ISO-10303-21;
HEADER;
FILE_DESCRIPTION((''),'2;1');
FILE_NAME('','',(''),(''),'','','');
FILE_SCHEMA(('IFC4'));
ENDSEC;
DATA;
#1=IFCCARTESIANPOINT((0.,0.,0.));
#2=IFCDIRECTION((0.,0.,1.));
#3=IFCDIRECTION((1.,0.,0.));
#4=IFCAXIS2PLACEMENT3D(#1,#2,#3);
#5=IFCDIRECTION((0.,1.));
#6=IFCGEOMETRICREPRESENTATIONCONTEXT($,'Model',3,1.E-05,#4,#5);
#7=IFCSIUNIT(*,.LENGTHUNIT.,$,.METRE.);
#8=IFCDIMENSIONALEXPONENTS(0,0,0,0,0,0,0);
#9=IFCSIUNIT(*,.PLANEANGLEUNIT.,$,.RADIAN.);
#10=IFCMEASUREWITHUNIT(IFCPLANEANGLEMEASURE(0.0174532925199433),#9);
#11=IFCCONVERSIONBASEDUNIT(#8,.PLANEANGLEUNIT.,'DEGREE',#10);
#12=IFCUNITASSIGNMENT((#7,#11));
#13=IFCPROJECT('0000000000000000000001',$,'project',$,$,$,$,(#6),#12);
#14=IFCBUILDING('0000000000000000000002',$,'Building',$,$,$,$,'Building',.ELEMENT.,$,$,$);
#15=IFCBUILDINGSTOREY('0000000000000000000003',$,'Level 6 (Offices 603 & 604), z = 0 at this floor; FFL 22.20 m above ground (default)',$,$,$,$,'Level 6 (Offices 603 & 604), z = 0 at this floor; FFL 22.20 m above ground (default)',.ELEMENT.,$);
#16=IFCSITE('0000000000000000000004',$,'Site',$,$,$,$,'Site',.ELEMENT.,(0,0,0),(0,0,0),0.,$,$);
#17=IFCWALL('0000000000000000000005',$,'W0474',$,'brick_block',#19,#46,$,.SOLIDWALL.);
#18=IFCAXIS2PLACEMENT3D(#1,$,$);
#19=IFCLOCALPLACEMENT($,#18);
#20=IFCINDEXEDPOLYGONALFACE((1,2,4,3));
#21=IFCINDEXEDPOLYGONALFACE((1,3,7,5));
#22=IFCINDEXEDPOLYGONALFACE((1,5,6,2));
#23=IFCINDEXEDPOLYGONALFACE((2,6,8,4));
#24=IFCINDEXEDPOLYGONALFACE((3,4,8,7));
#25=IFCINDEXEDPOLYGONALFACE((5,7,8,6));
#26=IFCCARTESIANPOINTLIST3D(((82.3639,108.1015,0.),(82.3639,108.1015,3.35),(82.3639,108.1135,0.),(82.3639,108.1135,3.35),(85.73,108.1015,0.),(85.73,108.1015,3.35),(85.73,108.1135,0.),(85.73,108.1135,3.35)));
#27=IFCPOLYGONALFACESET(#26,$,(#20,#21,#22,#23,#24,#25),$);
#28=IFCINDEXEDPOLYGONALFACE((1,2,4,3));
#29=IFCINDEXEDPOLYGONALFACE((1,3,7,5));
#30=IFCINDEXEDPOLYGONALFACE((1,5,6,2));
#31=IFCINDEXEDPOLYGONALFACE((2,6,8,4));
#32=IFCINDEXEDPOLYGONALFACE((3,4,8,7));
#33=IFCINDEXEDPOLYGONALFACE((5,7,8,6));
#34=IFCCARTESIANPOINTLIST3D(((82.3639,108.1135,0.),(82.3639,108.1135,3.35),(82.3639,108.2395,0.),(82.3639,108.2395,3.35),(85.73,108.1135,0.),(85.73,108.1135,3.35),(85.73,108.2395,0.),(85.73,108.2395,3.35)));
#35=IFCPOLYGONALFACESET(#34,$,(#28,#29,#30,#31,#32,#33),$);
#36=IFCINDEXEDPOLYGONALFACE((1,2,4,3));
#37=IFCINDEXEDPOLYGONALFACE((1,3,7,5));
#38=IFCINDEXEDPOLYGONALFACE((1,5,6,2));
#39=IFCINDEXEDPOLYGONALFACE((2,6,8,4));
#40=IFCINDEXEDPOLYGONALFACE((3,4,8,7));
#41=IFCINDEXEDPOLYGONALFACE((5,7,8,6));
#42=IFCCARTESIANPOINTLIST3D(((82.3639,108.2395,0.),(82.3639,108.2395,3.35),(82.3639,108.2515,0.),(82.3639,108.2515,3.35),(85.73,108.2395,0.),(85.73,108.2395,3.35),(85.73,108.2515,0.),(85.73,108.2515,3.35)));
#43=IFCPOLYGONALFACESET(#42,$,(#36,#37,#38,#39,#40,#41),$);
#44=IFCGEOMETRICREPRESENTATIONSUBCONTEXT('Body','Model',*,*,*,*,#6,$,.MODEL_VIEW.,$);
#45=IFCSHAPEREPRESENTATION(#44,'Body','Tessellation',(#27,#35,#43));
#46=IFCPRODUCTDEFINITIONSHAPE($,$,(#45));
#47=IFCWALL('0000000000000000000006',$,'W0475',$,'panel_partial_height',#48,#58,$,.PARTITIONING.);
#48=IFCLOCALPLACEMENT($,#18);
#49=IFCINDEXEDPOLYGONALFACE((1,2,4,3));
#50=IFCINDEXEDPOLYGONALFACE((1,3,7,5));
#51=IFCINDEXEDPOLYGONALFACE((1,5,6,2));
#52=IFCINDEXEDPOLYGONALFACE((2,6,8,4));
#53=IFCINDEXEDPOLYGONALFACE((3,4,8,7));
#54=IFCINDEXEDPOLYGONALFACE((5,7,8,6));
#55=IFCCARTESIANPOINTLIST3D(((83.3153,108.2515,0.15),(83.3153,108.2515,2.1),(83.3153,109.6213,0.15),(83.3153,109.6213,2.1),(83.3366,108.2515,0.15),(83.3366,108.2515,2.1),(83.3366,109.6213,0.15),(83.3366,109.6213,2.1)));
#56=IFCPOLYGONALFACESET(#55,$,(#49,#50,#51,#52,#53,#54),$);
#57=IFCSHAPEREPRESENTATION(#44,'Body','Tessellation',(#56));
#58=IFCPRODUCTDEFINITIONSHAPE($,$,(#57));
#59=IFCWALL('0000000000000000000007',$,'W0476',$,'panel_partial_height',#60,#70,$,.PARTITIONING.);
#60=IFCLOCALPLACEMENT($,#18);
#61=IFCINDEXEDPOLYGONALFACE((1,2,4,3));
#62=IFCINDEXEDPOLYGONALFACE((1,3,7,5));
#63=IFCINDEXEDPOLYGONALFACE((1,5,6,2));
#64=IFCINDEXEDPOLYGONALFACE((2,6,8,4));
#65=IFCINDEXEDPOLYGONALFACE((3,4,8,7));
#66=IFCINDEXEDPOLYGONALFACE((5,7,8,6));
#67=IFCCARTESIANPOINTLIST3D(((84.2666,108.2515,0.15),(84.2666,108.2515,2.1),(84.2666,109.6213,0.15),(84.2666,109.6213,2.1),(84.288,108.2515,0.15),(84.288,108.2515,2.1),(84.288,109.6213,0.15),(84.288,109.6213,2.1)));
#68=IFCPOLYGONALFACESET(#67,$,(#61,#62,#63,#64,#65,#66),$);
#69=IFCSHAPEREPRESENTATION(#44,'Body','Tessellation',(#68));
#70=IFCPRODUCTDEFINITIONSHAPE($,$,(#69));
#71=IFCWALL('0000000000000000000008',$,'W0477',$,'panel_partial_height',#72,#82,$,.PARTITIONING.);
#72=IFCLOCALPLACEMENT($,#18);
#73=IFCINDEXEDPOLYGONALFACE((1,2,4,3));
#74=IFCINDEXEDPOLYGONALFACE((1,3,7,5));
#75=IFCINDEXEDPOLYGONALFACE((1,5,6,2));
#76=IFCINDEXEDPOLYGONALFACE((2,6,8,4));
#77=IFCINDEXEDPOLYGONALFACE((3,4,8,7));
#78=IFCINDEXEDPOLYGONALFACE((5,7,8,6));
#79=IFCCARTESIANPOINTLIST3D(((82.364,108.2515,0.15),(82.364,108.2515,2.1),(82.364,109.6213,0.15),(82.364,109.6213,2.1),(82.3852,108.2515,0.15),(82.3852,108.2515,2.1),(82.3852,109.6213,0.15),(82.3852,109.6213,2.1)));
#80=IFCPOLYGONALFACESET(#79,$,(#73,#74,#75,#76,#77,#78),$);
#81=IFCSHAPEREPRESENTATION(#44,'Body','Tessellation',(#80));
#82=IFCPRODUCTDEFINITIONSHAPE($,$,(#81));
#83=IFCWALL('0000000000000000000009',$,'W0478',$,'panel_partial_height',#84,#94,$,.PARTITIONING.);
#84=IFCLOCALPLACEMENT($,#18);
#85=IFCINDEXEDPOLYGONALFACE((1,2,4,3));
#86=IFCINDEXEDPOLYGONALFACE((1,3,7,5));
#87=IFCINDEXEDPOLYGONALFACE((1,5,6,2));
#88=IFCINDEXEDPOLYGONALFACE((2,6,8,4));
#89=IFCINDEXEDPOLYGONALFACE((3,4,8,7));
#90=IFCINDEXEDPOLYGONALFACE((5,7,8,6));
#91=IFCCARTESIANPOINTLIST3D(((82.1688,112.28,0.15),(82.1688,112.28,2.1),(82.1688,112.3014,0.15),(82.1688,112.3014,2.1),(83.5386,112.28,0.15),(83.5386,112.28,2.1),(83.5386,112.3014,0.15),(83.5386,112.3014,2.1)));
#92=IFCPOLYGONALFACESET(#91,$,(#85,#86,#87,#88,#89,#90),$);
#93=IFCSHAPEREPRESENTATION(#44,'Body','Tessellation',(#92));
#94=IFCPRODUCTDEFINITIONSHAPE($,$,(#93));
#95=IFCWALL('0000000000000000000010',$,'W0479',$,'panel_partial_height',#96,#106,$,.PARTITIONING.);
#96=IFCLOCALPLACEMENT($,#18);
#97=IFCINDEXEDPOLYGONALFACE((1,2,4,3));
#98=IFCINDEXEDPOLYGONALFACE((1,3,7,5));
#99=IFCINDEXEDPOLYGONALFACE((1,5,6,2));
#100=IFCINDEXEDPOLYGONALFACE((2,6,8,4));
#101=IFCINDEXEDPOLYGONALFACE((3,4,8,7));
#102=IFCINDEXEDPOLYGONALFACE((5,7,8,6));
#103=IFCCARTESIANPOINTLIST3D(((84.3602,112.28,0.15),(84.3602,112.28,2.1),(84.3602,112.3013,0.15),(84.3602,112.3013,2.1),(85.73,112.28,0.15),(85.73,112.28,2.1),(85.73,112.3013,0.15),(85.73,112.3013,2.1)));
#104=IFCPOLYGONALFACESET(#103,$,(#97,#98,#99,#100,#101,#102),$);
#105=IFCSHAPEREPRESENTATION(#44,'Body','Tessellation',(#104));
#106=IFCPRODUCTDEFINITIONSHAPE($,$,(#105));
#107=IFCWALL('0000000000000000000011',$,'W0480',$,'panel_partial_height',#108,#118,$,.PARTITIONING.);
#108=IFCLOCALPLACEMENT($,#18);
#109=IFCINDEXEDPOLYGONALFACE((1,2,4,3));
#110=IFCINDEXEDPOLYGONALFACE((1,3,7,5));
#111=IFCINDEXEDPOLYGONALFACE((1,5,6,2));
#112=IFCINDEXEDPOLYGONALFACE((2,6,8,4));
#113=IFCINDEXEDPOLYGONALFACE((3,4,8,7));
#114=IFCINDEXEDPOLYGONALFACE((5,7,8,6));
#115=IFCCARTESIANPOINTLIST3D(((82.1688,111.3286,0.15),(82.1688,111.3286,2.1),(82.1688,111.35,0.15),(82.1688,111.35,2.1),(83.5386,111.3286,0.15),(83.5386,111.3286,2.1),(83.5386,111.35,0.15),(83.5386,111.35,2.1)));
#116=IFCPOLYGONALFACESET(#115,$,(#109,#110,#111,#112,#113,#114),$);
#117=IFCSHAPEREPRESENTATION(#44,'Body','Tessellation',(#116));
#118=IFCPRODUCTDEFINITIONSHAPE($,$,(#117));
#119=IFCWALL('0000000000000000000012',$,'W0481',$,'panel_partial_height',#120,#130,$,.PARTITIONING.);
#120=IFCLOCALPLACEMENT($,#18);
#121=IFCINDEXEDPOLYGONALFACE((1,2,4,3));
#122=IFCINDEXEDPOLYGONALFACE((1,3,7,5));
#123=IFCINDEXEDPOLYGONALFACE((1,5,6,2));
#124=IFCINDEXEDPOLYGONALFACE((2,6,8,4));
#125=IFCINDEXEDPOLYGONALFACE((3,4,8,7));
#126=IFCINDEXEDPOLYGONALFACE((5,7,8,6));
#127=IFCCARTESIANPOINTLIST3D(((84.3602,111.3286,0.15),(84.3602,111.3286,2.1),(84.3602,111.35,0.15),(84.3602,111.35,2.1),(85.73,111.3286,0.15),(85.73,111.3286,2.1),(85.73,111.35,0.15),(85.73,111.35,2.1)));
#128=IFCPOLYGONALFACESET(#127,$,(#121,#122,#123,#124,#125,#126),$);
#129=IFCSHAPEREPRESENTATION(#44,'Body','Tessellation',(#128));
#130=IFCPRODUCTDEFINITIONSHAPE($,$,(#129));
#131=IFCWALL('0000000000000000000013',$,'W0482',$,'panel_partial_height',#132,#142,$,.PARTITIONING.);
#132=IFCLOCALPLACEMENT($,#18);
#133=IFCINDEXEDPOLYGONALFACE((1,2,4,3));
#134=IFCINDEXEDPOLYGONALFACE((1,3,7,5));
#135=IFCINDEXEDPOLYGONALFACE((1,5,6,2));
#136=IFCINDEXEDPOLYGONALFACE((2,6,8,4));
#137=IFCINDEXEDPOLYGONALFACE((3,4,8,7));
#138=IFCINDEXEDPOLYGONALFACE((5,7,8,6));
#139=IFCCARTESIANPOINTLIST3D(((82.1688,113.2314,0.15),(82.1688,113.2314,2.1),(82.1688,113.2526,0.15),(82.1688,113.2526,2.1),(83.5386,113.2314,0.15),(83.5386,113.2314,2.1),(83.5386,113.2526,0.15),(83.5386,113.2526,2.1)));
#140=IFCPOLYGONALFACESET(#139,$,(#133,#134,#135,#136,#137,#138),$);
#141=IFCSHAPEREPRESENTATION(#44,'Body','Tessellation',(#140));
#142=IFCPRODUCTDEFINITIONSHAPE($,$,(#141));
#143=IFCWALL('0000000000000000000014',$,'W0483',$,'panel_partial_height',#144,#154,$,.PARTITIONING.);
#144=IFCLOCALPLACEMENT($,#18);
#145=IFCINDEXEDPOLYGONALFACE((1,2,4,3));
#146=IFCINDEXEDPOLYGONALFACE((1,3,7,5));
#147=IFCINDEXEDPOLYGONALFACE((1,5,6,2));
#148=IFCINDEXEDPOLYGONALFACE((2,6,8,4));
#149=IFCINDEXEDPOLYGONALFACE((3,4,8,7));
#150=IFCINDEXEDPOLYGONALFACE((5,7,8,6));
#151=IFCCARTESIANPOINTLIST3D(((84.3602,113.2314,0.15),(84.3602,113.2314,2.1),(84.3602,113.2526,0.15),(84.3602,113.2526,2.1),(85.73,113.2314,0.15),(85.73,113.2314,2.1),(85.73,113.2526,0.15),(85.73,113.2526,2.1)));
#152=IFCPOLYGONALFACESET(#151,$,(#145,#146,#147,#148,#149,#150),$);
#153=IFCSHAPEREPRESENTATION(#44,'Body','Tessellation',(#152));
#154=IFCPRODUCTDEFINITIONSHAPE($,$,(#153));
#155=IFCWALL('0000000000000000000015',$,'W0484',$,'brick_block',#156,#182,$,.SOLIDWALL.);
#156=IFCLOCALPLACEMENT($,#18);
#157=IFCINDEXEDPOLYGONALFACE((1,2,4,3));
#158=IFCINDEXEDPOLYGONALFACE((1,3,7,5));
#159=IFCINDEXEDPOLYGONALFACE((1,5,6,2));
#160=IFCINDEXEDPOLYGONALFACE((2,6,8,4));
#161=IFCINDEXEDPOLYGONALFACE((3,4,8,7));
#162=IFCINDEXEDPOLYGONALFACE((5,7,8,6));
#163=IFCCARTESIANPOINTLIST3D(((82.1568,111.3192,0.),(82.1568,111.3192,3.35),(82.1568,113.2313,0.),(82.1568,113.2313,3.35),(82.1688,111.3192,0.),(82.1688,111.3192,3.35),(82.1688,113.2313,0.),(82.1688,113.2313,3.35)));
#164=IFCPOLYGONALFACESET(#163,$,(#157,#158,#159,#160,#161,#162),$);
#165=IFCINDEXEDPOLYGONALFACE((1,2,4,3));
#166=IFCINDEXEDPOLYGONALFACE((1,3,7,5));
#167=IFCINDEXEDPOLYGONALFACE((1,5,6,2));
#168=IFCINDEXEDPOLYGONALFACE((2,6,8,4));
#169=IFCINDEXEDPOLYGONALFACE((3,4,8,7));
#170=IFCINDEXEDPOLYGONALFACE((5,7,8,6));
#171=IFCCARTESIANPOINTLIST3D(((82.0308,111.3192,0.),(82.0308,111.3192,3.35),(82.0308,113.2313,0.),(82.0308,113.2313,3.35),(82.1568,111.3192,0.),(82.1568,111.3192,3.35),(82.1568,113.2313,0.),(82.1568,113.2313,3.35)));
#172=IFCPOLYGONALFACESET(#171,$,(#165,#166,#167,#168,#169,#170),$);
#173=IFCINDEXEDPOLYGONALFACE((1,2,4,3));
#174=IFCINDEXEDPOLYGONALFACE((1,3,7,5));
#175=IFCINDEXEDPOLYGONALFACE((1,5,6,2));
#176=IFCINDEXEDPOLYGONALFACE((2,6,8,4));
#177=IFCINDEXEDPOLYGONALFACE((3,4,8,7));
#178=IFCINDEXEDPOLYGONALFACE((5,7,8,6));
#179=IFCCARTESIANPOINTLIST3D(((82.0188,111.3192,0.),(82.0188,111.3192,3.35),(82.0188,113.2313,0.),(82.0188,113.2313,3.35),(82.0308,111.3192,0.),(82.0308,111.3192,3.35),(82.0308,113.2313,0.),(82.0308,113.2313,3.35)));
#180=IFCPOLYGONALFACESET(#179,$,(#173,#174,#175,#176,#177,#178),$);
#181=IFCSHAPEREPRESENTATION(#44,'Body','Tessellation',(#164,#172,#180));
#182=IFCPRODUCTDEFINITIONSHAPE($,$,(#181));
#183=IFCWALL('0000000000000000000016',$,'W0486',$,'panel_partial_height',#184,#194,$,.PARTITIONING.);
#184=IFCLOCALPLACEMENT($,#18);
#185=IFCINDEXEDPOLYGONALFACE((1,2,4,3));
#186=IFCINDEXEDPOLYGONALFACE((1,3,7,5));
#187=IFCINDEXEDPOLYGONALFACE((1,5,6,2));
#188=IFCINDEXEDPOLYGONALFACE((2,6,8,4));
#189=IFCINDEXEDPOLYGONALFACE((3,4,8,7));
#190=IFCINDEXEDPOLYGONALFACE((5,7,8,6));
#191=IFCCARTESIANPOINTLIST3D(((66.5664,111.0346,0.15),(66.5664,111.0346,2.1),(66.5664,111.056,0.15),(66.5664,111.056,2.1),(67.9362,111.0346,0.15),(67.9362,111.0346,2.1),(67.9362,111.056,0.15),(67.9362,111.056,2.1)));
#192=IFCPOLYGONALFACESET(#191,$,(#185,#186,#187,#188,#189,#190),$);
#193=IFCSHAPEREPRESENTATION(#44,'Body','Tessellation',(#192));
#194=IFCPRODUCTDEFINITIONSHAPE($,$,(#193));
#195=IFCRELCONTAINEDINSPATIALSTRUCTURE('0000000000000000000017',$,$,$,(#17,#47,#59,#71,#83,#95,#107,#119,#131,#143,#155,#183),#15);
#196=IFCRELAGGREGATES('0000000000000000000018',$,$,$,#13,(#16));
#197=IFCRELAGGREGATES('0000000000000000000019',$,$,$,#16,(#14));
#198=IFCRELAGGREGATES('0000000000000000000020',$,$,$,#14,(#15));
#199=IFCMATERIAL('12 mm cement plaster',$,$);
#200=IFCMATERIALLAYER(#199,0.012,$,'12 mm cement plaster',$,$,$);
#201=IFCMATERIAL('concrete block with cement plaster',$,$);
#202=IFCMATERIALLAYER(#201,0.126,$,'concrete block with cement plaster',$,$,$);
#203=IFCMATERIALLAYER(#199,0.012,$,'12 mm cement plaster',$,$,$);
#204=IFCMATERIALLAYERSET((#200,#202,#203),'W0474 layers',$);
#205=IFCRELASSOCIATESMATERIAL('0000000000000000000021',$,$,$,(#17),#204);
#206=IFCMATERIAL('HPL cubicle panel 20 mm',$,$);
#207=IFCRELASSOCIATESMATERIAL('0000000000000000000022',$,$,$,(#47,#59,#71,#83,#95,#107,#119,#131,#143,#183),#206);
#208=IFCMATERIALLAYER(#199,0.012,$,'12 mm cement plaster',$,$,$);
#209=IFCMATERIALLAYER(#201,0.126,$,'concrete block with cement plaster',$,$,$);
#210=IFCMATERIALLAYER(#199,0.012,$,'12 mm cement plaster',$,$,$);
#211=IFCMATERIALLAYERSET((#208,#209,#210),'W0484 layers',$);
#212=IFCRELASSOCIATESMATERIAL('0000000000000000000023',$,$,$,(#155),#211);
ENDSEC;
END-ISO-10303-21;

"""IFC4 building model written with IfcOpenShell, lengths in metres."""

from ifc_helpers import new_model, entity, si_unit, converted_unit, direction, frame, frame_2d, origin_with_axes, origin_2d_with_axis, place, context, subcontext, project, spatial, rectangle, extrude, material, layer, layer_set, layer_usage, element, save


model = new_model("IFC4")

# Units and contexts
model_context = context("Model", 3, precision=1e-05, world=origin_with_axes(), true_north=direction((0.0, 1.0)))
body_context = subcontext(model_context, "Body", "Model", "MODEL_VIEW")
ifc_project = project(units=[si_unit("LENGTHUNIT", "METRE"), converted_unit("PLANEANGLEUNIT", "DEGREE", entity("IfcPlaneAngleMeasure", 0.0174532925199433), si_unit("PLANEANGLEUNIT", "RADIAN"), dimensions=[0, 0, 0, 0, 0, 0, 0])], contexts=[model_context])

# Site, building, storey
site = spatial("IfcSite", under=ifc_project, Name="Site", LongName="Site", CompositionType="ELEMENT", RefLatitude=(0, 0, 0), RefLongitude=(0, 0, 0), RefElevation=0.0)
building = spatial("IfcBuilding", under=site, Name="Building", LongName="Building", CompositionType="ELEMENT")
storey = spatial("IfcBuildingStorey", under=building, Name="Level 6 (Offices 603 & 604), z = 0 at this floor; FFL 22.20 m above ground (default)", LongName="Level 6 (Offices 603 & 604), z = 0 at this floor; FFL 22.20 m above ground (default)", CompositionType="ELEMENT")

# Walls
placement = place(None, origin_with_axes())
ifc_material_1 = material(Name="HPL cubicle panel 20 mm")
ifc_material_2 = material(Name="12 mm cement plaster")
ifc_material_3 = material(Name="concrete block with cement plaster")
ifc_layer_1 = layer(ifc_material_2, 0.012, Name="12 mm cement plaster")
ifc_layer_2 = layer(ifc_material_3, 0.126, Name="concrete block with cement plaster")
ifc_layer_3 = layer(ifc_material_2, 0.012, Name="12 mm cement plaster")
ifc_layer_set_1 = layer_set([ifc_layer_1, ifc_layer_2, ifc_layer_3], Name="W0474 layers")
ifc_layer_usage_1 = layer_usage(ifc_layer_set_1, "AXIS2", "POSITIVE", -0.075)
element("IfcWall", 1, at=placement, inside=storey, material=ifc_layer_usage_1, Name="W0474", ObjectType="brick_block", PredefinedType="SOLIDWALL", context=body_context, shape_type="SweptSolid", body=[
    extrude(rectangle(XDim=3.3661, YDim=0.012, at=frame_2d((0.0, 0.0), x_axis=(1.0, 0.0))), frame((84.0469, 108.1075, 0.0), z_axis=(0.0, 0.0, 1.0), x_axis=(1.0, 0.0, 0.0)), (0.0, 0.0, 1.0), 3.35),
    extrude(rectangle(XDim=3.3661, YDim=0.126, at=frame_2d((0.0, 0.069), x_axis=(1.0, 0.0))), frame((84.0469, 108.1075, 0.0), z_axis=(0.0, 0.0, 1.0), x_axis=(1.0, 0.0, 0.0)), (0.0, 0.0, 1.0), 3.35),
    extrude(rectangle(XDim=3.3661, YDim=0.012, at=frame_2d((0.0, 0.138), x_axis=(1.0, 0.0))), frame((84.0469, 108.1075, 0.0), z_axis=(0.0, 0.0, 1.0), x_axis=(1.0, 0.0, 0.0)), (0.0, 0.0, 1.0), 3.35),
])
element("IfcWall", 2, at=placement, inside=storey, material=ifc_material_1, Name="W0475", ObjectType="panel_partial_height", PredefinedType="PARTITIONING", context=body_context, shape_type="SweptSolid", body=[
    extrude(rectangle(XDim=1.3698, YDim=0.0213, at=frame_2d((0.0, 0.0), x_axis=(0.0, 1.0))), frame((83.3259, 108.9364, 0.15), z_axis=(0.0, 0.0, 1.0), x_axis=(1.0, 0.0, 0.0)), (0.0, 0.0, 1.0), 1.95),
])
element("IfcWall", 3, at=placement, inside=storey, material=ifc_material_1, Name="W0476", ObjectType="panel_partial_height", PredefinedType="PARTITIONING", context=body_context, shape_type="SweptSolid", body=[
    extrude(rectangle(XDim=1.3698, YDim=0.0213, at=frame_2d((0.0, 0.0), x_axis=(0.0, 1.0))), frame((84.2773, 108.9364, 0.15), z_axis=(0.0, 0.0, 1.0), x_axis=(1.0, 0.0, 0.0)), (0.0, 0.0, 1.0), 1.95),
])
element("IfcWall", 4, at=placement, inside=storey, material=ifc_material_1, Name="W0477", ObjectType="panel_partial_height", PredefinedType="PARTITIONING", context=body_context, shape_type="SweptSolid", body=[
    extrude(rectangle(XDim=1.3698, YDim=0.0213, at=frame_2d((0.0, 0.0), x_axis=(0.0, 1.0))), frame((82.3746, 108.9364, 0.15), z_axis=(0.0, 0.0, 1.0), x_axis=(1.0, 0.0, 0.0)), (0.0, 0.0, 1.0), 1.95),
])
element("IfcWall", 5, at=placement, inside=storey, material=ifc_material_1, Name="W0478", ObjectType="panel_partial_height", PredefinedType="PARTITIONING", context=body_context, shape_type="SweptSolid", body=[
    extrude(rectangle(XDim=1.3698, YDim=0.0213, at=origin_2d_with_axis()), frame((82.8537, 112.2907, 0.15), z_axis=(0.0, 0.0, 1.0), x_axis=(1.0, 0.0, 0.0)), (0.0, 0.0, 1.0), 1.95),
])
element("IfcWall", 6, at=placement, inside=storey, material=ifc_material_1, Name="W0479", ObjectType="panel_partial_height", PredefinedType="PARTITIONING", context=body_context, shape_type="SweptSolid", body=[
    extrude(rectangle(XDim=1.3698, YDim=0.0213, at=frame_2d((0.0, 0.0), x_axis=(1.0, 0.0))), frame((85.0451, 112.2907, 0.15), z_axis=(0.0, 0.0, 1.0), x_axis=(1.0, 0.0, 0.0)), (0.0, 0.0, 1.0), 1.95),
])
element("IfcWall", 7, at=placement, inside=storey, material=ifc_material_1, Name="W0480", ObjectType="panel_partial_height", PredefinedType="PARTITIONING", context=body_context, shape_type="SweptSolid", body=[
    extrude(rectangle(XDim=1.3698, YDim=0.0213, at=origin_2d_with_axis()), frame((82.8537, 111.3393, 0.15), z_axis=(0.0, 0.0, 1.0), x_axis=(1.0, 0.0, 0.0)), (0.0, 0.0, 1.0), 1.95),
])
element("IfcWall", 8, at=placement, inside=storey, material=ifc_material_1, Name="W0481", ObjectType="panel_partial_height", PredefinedType="PARTITIONING", context=body_context, shape_type="SweptSolid", body=[
    extrude(rectangle(XDim=1.3698, YDim=0.0213, at=frame_2d((0.0, 0.0), x_axis=(1.0, 0.0))), frame((85.0451, 111.3393, 0.15), z_axis=(0.0, 0.0, 1.0), x_axis=(1.0, 0.0, 0.0)), (0.0, 0.0, 1.0), 1.95),
])
element("IfcWall", 9, at=placement, inside=storey, material=ifc_material_1, Name="W0482", ObjectType="panel_partial_height", PredefinedType="PARTITIONING", context=body_context, shape_type="SweptSolid", body=[
    extrude(rectangle(XDim=1.3698, YDim=0.0213, at=origin_2d_with_axis()), frame((82.8537, 113.242, 0.15), z_axis=(0.0, 0.0, 1.0), x_axis=(1.0, 0.0, 0.0)), (0.0, 0.0, 1.0), 1.95),
])
element("IfcWall", 10, at=placement, inside=storey, material=ifc_material_1, Name="W0483", ObjectType="panel_partial_height", PredefinedType="PARTITIONING", context=body_context, shape_type="SweptSolid", body=[
    extrude(rectangle(XDim=1.3698, YDim=0.0213, at=frame_2d((0.0, 0.0), x_axis=(1.0, 0.0))), frame((85.0451, 113.242, 0.15), z_axis=(0.0, 0.0, 1.0), x_axis=(1.0, 0.0, 0.0)), (0.0, 0.0, 1.0), 1.95),
])
ifc_layer_4 = layer(ifc_material_2, 0.012, Name="12 mm cement plaster")
ifc_layer_5 = layer(ifc_material_3, 0.126, Name="concrete block with cement plaster")
ifc_layer_6 = layer(ifc_material_2, 0.012, Name="12 mm cement plaster")
ifc_layer_set_2 = layer_set([ifc_layer_4, ifc_layer_5, ifc_layer_6], Name="W0484 layers")
ifc_layer_usage_2 = layer_usage(ifc_layer_set_2, "AXIS2", "POSITIVE", -0.075)
element("IfcWall", 11, at=placement, inside=storey, material=ifc_layer_usage_2, Name="W0484", ObjectType="brick_block", PredefinedType="SOLIDWALL", context=body_context, shape_type="SweptSolid", body=[
    extrude(rectangle(XDim=1.9121, YDim=0.012, at=frame_2d((0.0, 0.0), x_axis=(0.0, 1.0))), frame((82.1628, 112.2752, 0.0), z_axis=(0.0, 0.0, 1.0), x_axis=(1.0, 0.0, 0.0)), (0.0, 0.0, 1.0), 3.35),
    extrude(rectangle(XDim=1.9121, YDim=0.126, at=frame_2d((-0.069, 0.0), x_axis=(0.0, 1.0))), frame((82.1628, 112.2752, 0.0), z_axis=(0.0, 0.0, 1.0), x_axis=(1.0, 0.0, 0.0)), (0.0, 0.0, 1.0), 3.35),
    extrude(rectangle(XDim=1.9121, YDim=0.012, at=frame_2d((-0.138, 0.0), x_axis=(0.0, 1.0))), frame((82.1628, 112.2752, 0.0), z_axis=(0.0, 0.0, 1.0), x_axis=(1.0, 0.0, 0.0)), (0.0, 0.0, 1.0), 3.35),
])
element("IfcWall", 12, at=placement, inside=storey, material=ifc_material_1, Name="W0486", ObjectType="panel_partial_height", PredefinedType="PARTITIONING", context=body_context, shape_type="SweptSolid", body=[
    extrude(rectangle(XDim=1.3698, YDim=0.0213, at=frame_2d((0.0, 0.0), x_axis=(1.0, 0.0))), frame((67.2513, 111.0453, 0.15), z_axis=(0.0, 0.0, 1.0), x_axis=(1.0, 0.0, 0.0)), (0.0, 0.0, 1.0), 1.95),
])

save(model, "model.ifc")
